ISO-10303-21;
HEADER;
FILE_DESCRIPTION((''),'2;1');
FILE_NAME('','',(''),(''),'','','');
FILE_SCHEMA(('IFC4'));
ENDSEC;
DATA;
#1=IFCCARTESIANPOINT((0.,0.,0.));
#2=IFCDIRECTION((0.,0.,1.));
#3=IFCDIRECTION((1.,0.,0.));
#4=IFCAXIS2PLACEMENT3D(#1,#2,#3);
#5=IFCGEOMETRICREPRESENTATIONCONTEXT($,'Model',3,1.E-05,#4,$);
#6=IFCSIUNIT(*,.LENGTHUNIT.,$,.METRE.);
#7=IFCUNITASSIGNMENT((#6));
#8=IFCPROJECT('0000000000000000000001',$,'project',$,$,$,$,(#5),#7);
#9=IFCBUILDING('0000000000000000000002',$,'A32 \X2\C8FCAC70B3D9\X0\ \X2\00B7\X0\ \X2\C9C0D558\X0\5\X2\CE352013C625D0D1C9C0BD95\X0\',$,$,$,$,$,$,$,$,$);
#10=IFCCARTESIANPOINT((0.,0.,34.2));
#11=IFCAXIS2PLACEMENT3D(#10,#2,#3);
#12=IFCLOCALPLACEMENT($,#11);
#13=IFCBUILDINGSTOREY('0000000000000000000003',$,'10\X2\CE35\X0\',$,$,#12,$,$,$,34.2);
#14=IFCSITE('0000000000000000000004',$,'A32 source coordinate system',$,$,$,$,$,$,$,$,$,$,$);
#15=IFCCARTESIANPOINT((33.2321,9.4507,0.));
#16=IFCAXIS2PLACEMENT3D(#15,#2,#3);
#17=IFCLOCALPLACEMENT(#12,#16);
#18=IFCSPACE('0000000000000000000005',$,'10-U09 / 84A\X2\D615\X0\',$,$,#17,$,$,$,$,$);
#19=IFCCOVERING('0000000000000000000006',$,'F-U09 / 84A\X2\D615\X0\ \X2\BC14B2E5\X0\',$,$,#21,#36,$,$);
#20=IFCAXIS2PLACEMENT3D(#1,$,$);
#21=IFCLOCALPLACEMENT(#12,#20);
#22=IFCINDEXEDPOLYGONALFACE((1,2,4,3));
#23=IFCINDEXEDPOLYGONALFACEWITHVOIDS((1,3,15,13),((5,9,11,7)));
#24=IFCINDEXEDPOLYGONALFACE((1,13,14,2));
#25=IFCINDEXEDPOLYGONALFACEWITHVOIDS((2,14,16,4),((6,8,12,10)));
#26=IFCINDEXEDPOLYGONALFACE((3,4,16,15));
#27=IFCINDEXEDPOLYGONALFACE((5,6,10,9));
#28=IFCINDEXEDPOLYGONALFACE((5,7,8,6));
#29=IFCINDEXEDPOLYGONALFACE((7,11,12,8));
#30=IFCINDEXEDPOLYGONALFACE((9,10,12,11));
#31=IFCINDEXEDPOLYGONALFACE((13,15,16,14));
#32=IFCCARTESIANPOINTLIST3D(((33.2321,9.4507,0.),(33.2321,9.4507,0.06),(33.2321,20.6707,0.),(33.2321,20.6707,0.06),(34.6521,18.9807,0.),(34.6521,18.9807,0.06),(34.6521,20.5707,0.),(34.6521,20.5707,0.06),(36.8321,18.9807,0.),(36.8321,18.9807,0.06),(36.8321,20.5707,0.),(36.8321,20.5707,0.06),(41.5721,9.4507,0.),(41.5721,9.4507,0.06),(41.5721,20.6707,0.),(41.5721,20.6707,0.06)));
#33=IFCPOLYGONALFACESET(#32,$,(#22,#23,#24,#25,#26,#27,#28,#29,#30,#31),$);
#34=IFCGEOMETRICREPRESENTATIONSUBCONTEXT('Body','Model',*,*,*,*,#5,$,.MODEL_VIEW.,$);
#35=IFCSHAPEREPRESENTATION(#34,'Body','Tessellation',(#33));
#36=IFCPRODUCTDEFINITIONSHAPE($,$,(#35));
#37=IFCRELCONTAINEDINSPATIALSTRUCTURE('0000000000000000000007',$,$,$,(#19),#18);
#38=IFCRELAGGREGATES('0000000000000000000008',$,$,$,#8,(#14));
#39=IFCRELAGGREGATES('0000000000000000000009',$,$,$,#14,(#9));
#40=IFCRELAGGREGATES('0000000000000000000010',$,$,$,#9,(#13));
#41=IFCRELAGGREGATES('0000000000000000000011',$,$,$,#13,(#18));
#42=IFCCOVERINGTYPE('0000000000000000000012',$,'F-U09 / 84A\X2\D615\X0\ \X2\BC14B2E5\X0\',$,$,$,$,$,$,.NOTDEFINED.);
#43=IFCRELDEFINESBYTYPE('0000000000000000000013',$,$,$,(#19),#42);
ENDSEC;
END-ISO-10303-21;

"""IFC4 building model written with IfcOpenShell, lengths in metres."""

from ifc_helpers import new_model, si_unit, frame, origin, origin_with_axes, place, context, subcontext, project, spatial, polyline, outline, extrude, source, transform, mapped, type_object, type_shapes, element, save


model = new_model("IFC4")

# Units and contexts
model_context = context("Model", 3, precision=1e-05, world=origin_with_axes())
body_context = subcontext(model_context, "Body", "Model", "MODEL_VIEW")
ifc_project = project(units=[si_unit("LENGTHUNIT", "METRE")], contexts=[model_context])

# Site, building, storey, space
storey_placement = place(None, frame((0.0, 0.0, 34.2), z_axis=(0.0, 0.0, 1.0), x_axis=(1.0, 0.0, 0.0)))
space_placement = place(storey_placement, frame((33.2321, 9.4507, 0.0), z_axis=(0.0, 0.0, 1.0), x_axis=(1.0, 0.0, 0.0)))
site = spatial("IfcSite", under=ifc_project, Name="A32 source coordinate system")
building = spatial("IfcBuilding", under=site, Name="A32 주거동 · 지하5층–옥탑지붕")
storey = spatial("IfcBuildingStorey", under=building, at=storey_placement, Name="10층", Elevation=34.2)
space = spatial("IfcSpace", under=storey, at=space_placement, Name="10-U09 / 84A형")

# Covering
covering_type_1 = type_object("IfcCoveringType", Name="F-U09 / 84A형 바닥", PredefinedType="NOTDEFINED")
shared_shape_1 = source(origin(), body_context, "Body", "SweptSolid", [
    extrude(outline(polyline([(0.0, 0.0), (0.0, 11.22), (8.34, 11.22), (8.34, 0.0), (0.0, 0.0)]), holes=[polyline([(1.42, 11.12), (1.42, 9.53), (3.6, 9.53), (3.6, 11.12), (1.42, 11.12)])]), origin(), (0.0, 0.0, 1.0), 0.06),
])
type_shapes(covering_type_1, [shared_shape_1])
covering_1_placement = place(space_placement, origin_with_axes())
element("IfcCovering", 1, at=covering_1_placement, inside=space, type_object=covering_type_1, Name="F-U09 / 84A형 바닥", context=body_context, shape_type="MappedRepresentation", body=[
    mapped(shared_shape_1, transform((0.0, 0.0, 0.0), scale=1.0)),
])

save(model, "model.ifc")
